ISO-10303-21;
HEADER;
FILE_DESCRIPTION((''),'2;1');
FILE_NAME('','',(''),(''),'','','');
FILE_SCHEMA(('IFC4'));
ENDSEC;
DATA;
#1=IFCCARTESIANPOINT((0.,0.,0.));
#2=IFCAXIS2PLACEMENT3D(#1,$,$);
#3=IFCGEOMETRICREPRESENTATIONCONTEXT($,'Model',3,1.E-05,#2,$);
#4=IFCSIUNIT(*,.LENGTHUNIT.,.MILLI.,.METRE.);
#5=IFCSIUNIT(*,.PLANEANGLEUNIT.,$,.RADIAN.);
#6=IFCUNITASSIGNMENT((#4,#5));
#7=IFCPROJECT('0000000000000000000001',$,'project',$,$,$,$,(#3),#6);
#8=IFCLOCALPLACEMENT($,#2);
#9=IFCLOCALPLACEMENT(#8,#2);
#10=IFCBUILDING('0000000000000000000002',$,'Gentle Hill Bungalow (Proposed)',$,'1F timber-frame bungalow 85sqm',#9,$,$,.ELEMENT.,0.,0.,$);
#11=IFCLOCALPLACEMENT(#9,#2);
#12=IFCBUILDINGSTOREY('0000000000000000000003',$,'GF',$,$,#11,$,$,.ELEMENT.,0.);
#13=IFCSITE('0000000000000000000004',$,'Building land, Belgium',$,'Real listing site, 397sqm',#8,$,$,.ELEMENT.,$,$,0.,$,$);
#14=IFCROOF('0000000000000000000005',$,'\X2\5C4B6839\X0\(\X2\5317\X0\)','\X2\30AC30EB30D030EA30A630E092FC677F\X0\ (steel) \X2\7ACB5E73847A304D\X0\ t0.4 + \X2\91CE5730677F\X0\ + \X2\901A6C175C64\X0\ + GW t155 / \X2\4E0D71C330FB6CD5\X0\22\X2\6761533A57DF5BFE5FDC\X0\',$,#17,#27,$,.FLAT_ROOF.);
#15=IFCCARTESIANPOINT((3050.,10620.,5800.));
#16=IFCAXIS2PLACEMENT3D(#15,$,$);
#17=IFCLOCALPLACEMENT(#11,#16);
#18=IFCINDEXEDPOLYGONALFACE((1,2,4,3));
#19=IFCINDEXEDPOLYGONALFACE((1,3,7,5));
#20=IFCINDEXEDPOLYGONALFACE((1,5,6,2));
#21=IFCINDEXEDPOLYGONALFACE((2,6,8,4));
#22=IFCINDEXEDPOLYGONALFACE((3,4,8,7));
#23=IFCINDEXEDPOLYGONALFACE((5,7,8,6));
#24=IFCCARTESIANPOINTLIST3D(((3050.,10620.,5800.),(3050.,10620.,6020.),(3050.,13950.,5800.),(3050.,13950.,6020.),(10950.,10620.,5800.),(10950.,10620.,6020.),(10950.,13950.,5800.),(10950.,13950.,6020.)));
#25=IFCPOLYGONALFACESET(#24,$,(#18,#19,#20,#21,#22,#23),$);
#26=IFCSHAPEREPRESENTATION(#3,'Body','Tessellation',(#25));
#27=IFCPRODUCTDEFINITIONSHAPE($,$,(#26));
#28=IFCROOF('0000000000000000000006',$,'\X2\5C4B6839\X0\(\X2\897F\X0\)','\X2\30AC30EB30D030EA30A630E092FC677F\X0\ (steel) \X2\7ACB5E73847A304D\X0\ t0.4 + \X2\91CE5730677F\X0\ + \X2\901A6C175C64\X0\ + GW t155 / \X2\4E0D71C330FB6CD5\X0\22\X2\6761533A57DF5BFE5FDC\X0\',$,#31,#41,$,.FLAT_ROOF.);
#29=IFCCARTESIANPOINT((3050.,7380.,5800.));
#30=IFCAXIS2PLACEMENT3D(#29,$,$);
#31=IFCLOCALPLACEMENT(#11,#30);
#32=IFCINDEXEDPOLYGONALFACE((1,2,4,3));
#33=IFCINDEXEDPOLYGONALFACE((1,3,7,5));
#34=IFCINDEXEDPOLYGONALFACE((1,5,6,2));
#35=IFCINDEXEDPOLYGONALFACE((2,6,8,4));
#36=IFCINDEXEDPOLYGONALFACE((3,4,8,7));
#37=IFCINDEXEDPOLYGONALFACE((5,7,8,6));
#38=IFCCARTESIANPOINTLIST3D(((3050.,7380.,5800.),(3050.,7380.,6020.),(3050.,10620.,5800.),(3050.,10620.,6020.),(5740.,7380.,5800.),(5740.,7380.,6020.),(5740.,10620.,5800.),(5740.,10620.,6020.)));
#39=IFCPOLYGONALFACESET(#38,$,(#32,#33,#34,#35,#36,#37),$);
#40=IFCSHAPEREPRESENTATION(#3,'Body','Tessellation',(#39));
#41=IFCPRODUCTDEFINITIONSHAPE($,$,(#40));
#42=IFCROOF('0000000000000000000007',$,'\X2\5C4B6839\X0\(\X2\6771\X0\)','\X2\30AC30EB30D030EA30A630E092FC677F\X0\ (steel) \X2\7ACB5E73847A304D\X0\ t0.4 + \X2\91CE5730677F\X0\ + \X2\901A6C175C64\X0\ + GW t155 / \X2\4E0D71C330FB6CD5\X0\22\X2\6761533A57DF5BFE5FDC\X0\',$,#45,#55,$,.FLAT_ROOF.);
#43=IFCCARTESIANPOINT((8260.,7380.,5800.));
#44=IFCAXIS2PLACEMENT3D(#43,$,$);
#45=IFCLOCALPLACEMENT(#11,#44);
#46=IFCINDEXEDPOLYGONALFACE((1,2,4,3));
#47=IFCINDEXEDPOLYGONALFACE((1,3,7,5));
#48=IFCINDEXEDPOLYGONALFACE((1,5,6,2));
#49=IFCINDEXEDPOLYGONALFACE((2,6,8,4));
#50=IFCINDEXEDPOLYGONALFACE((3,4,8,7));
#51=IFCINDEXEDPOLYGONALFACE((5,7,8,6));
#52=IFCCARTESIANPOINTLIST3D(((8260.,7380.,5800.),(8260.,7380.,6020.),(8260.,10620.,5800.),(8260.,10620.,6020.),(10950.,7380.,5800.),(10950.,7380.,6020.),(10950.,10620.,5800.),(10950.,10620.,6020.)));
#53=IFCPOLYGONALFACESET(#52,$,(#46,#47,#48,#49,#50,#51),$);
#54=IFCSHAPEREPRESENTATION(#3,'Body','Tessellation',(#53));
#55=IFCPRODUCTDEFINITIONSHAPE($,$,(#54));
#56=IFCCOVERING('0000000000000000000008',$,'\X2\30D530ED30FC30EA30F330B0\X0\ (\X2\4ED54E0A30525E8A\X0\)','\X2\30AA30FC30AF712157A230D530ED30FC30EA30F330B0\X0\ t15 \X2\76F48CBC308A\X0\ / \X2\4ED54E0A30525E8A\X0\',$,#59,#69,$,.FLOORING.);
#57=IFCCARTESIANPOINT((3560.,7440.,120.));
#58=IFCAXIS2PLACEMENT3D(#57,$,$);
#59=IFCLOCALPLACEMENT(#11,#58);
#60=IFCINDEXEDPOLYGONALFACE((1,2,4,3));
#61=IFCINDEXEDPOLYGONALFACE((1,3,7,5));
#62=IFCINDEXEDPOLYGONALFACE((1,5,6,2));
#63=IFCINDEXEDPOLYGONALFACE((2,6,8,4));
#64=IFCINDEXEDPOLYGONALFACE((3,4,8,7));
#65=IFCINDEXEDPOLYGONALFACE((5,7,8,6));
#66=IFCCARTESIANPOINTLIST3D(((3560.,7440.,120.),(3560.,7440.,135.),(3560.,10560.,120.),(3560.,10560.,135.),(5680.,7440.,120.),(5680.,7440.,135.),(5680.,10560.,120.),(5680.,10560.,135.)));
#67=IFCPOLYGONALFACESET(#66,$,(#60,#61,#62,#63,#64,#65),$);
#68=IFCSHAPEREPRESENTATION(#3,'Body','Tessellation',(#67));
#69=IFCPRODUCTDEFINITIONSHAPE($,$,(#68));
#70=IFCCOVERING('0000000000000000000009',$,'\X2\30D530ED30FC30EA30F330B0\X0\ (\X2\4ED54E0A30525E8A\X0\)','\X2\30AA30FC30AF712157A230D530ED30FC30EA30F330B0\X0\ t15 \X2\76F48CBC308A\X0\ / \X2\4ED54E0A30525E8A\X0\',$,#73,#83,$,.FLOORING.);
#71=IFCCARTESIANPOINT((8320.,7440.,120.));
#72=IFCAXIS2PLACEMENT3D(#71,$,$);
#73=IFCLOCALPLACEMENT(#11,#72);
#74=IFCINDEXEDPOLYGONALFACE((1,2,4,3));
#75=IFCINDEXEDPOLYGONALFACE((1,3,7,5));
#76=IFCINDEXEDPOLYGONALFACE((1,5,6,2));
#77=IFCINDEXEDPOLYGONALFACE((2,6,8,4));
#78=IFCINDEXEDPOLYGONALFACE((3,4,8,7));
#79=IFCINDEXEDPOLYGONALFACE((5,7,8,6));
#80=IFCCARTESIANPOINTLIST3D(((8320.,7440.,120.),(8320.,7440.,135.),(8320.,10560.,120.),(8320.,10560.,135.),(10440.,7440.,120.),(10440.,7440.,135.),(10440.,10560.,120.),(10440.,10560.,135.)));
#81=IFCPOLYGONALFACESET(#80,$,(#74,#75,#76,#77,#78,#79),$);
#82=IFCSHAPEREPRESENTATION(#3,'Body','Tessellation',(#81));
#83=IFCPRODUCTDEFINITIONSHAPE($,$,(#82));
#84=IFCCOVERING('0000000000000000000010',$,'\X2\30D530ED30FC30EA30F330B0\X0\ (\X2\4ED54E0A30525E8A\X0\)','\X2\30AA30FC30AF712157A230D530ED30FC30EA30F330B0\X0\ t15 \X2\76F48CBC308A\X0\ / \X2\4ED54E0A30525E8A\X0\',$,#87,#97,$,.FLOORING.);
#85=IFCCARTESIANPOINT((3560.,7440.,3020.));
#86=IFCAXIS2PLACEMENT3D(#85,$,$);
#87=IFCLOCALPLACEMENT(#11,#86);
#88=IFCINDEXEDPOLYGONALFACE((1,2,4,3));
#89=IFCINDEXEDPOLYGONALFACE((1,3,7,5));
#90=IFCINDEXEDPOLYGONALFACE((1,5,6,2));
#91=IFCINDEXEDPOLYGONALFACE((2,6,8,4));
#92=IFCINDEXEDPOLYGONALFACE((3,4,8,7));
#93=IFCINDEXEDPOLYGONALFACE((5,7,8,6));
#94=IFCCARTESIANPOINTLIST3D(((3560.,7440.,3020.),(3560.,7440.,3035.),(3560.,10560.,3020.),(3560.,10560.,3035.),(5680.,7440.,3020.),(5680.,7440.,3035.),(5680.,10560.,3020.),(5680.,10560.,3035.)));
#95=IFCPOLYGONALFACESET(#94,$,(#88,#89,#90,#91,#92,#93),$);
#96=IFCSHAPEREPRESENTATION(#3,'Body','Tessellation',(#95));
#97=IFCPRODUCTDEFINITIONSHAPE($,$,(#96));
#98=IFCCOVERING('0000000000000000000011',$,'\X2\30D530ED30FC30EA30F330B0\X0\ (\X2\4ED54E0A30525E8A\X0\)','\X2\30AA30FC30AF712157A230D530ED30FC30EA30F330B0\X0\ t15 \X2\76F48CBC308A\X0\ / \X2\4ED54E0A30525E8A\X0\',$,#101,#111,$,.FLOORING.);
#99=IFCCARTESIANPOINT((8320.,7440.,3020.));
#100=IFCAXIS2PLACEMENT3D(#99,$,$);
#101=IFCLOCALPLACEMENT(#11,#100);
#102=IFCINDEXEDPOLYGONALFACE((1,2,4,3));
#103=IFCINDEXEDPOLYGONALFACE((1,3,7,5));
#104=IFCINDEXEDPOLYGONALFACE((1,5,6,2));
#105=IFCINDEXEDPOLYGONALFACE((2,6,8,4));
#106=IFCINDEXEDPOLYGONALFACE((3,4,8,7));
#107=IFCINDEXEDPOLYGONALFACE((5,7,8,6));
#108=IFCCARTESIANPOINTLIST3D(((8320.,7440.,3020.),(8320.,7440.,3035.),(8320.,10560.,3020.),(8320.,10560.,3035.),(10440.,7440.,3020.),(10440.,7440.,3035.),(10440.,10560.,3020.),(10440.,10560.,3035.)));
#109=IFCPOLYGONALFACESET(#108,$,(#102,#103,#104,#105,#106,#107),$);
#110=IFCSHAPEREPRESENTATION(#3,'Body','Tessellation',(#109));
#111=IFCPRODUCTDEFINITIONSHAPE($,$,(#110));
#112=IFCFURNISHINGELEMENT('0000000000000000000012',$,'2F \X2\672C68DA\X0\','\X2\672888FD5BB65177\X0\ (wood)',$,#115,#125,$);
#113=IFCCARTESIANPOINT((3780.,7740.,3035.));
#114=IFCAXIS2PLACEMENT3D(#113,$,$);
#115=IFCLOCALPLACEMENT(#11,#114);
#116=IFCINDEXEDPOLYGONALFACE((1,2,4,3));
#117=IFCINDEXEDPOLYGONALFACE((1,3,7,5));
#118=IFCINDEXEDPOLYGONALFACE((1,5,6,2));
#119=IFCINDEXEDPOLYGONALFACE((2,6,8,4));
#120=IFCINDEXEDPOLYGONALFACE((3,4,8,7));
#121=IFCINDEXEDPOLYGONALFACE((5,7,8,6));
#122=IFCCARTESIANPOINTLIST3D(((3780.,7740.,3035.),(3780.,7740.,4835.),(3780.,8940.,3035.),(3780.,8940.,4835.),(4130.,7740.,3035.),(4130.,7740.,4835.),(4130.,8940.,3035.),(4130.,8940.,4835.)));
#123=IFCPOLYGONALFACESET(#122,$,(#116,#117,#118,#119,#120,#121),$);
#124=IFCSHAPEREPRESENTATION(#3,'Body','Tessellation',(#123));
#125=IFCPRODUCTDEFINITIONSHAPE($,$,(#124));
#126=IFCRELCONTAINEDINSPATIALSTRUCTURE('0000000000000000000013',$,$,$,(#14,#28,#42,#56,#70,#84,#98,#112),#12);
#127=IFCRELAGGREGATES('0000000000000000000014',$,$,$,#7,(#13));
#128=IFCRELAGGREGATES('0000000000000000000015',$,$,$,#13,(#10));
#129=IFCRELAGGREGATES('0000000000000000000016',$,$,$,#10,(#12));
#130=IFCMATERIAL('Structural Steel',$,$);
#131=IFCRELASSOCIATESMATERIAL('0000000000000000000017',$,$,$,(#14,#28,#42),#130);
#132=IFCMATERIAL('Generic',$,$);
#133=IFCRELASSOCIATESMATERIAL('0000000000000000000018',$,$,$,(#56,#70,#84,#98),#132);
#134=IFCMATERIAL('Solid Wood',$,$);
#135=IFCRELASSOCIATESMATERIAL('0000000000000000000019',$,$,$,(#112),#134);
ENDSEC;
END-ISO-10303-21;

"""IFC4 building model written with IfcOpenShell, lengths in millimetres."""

from ifc_helpers import new_model, si_unit, frame, frame_2d, origin, place, context, project, spatial, rectangle, extrude, material, element, save


model = new_model("IFC4")

# Units and contexts
model_context = context("Model", 3, precision=1e-05, world=origin())
ifc_project = project(units=[si_unit("LENGTHUNIT", "METRE", prefix="MILLI"), si_unit("PLANEANGLEUNIT", "RADIAN")], contexts=[model_context])

# Site, building, storey
site_placement = place(None, origin())
site = spatial("IfcSite", under=ifc_project, at=site_placement, Name="Building land, Belgium", ObjectType="Real listing site, 397sqm", CompositionType="ELEMENT", RefElevation=0.0)
building_placement = place(site_placement, origin())
building = spatial("IfcBuilding", under=site, at=building_placement, Name="Gentle Hill Bungalow (Proposed)", ObjectType="1F timber-frame bungalow 85sqm", CompositionType="ELEMENT", ElevationOfRefHeight=0.0, ElevationOfTerrain=0.0)
storey_placement = place(building_placement, origin())
storey = spatial("IfcBuildingStorey", under=building, at=storey_placement, Name="GF", CompositionType="ELEMENT", Elevation=0.0)

# Shared definitions
ifc_material_1 = material(Name="Solid Wood")

# Shared definitions
ifc_material_2 = material(Name="Generic")

# Roofs
ifc_material_3 = material(Name="Structural Steel")
roof_1_placement = place(storey_placement, frame((3050.0, 10620.0, 5800.0)))
element("IfcRoof", 1, at=roof_1_placement, inside=storey, material=ifc_material_3, Name="屋根(北)", Description="ガルバリウム鋼板 (steel) 立平葺き t0.4 + 野地板 + 通気層 + GW t155 / 不燃・法22条区域対応", PredefinedType="FLAT_ROOF", context=model_context, shape_type="SweptSolid", body=[
    extrude(rectangle(XDim=7900.0, YDim=3330.0, at=frame_2d((3950.0, 1665.0))), frame((3050.0, 10620.0, 5800.0)), (0.0, 0.0, 1.0), 220.0),
])
roof_2_placement = place(storey_placement, frame((3050.0, 7380.0, 5800.0)))
element("IfcRoof", 2, at=roof_2_placement, inside=storey, material=ifc_material_3, Name="屋根(西)", Description="ガルバリウム鋼板 (steel) 立平葺き t0.4 + 野地板 + 通気層 + GW t155 / 不燃・法22条区域対応", PredefinedType="FLAT_ROOF", context=model_context, shape_type="SweptSolid", body=[
    extrude(rectangle(XDim=2690.0, YDim=3240.0, at=frame_2d((1345.0, 1620.0))), frame((3050.0, 7380.0, 5800.0)), (0.0, 0.0, 1.0), 220.0),
])
roof_3_placement = place(storey_placement, frame((8260.0, 7380.0, 5800.0)))
element("IfcRoof", 3, at=roof_3_placement, inside=storey, material=ifc_material_3, Name="屋根(東)", Description="ガルバリウム鋼板 (steel) 立平葺き t0.4 + 野地板 + 通気層 + GW t155 / 不燃・法22条区域対応", PredefinedType="FLAT_ROOF", context=model_context, shape_type="SweptSolid", body=[
    extrude(rectangle(XDim=2690.0, YDim=3240.0, at=frame_2d((1345.0, 1620.0))), frame((8260.0, 7380.0, 5800.0)), (0.0, 0.0, 1.0), 220.0),
])

# Coverings
covering_1_placement = place(storey_placement, frame((3560.0, 7440.0, 120.0)))
element("IfcCovering", 4, at=covering_1_placement, inside=storey, material=ifc_material_2, Name="フローリング (仕上げ床)", Description="オーク無垢フローリング t15 直貼り / 仕上げ床", PredefinedType="FLOORING", context=model_context, shape_type="SweptSolid", body=[
    extrude(rectangle(XDim=2120.0, YDim=3120.0, at=frame_2d((1060.0, 1560.0))), frame((3560.0, 7440.0, 120.0)), (0.0, 0.0, 1.0), 15.0),
])
covering_2_placement = place(storey_placement, frame((8320.0, 7440.0, 120.0)))
element("IfcCovering", 5, at=covering_2_placement, inside=storey, material=ifc_material_2, Name="フローリング (仕上げ床)", Description="オーク無垢フローリング t15 直貼り / 仕上げ床", PredefinedType="FLOORING", context=model_context, shape_type="SweptSolid", body=[
    extrude(rectangle(XDim=2120.0, YDim=3120.0, at=frame_2d((1060.0, 1560.0))), frame((8320.0, 7440.0, 120.0)), (0.0, 0.0, 1.0), 15.0),
])
covering_3_placement = place(storey_placement, frame((3560.0, 7440.0, 3020.0)))
element("IfcCovering", 6, at=covering_3_placement, inside=storey, material=ifc_material_2, Name="フローリング (仕上げ床)", Description="オーク無垢フローリング t15 直貼り / 仕上げ床", PredefinedType="FLOORING", context=model_context, shape_type="SweptSolid", body=[
    extrude(rectangle(XDim=2120.0, YDim=3120.0, at=frame_2d((1060.0, 1560.0))), frame((3560.0, 7440.0, 3020.0)), (0.0, 0.0, 1.0), 15.0),
])
covering_4_placement = place(storey_placement, frame((8320.0, 7440.0, 3020.0)))
element("IfcCovering", 7, at=covering_4_placement, inside=storey, material=ifc_material_2, Name="フローリング (仕上げ床)", Description="オーク無垢フローリング t15 直貼り / 仕上げ床", PredefinedType="FLOORING", context=model_context, shape_type="SweptSolid", body=[
    extrude(rectangle(XDim=2120.0, YDim=3120.0, at=frame_2d((1060.0, 1560.0))), frame((8320.0, 7440.0, 3020.0)), (0.0, 0.0, 1.0), 15.0),
])

# Furnishing element
furnishing_placement = place(storey_placement, frame((3780.0, 7740.0, 3035.0)))
element("IfcFurnishingElement", 8, at=furnishing_placement, inside=storey, material=ifc_material_1, Name="2F 本棚", Description="木製家具 (wood)", context=model_context, shape_type="SweptSolid", body=[
    extrude(rectangle(XDim=350.0, YDim=1200.0, at=frame_2d((175.0, 600.0))), frame((3780.0, 7740.0, 3035.0)), (0.0, 0.0, 1.0), 1800.0),
])

save(model, "model.ifc")
